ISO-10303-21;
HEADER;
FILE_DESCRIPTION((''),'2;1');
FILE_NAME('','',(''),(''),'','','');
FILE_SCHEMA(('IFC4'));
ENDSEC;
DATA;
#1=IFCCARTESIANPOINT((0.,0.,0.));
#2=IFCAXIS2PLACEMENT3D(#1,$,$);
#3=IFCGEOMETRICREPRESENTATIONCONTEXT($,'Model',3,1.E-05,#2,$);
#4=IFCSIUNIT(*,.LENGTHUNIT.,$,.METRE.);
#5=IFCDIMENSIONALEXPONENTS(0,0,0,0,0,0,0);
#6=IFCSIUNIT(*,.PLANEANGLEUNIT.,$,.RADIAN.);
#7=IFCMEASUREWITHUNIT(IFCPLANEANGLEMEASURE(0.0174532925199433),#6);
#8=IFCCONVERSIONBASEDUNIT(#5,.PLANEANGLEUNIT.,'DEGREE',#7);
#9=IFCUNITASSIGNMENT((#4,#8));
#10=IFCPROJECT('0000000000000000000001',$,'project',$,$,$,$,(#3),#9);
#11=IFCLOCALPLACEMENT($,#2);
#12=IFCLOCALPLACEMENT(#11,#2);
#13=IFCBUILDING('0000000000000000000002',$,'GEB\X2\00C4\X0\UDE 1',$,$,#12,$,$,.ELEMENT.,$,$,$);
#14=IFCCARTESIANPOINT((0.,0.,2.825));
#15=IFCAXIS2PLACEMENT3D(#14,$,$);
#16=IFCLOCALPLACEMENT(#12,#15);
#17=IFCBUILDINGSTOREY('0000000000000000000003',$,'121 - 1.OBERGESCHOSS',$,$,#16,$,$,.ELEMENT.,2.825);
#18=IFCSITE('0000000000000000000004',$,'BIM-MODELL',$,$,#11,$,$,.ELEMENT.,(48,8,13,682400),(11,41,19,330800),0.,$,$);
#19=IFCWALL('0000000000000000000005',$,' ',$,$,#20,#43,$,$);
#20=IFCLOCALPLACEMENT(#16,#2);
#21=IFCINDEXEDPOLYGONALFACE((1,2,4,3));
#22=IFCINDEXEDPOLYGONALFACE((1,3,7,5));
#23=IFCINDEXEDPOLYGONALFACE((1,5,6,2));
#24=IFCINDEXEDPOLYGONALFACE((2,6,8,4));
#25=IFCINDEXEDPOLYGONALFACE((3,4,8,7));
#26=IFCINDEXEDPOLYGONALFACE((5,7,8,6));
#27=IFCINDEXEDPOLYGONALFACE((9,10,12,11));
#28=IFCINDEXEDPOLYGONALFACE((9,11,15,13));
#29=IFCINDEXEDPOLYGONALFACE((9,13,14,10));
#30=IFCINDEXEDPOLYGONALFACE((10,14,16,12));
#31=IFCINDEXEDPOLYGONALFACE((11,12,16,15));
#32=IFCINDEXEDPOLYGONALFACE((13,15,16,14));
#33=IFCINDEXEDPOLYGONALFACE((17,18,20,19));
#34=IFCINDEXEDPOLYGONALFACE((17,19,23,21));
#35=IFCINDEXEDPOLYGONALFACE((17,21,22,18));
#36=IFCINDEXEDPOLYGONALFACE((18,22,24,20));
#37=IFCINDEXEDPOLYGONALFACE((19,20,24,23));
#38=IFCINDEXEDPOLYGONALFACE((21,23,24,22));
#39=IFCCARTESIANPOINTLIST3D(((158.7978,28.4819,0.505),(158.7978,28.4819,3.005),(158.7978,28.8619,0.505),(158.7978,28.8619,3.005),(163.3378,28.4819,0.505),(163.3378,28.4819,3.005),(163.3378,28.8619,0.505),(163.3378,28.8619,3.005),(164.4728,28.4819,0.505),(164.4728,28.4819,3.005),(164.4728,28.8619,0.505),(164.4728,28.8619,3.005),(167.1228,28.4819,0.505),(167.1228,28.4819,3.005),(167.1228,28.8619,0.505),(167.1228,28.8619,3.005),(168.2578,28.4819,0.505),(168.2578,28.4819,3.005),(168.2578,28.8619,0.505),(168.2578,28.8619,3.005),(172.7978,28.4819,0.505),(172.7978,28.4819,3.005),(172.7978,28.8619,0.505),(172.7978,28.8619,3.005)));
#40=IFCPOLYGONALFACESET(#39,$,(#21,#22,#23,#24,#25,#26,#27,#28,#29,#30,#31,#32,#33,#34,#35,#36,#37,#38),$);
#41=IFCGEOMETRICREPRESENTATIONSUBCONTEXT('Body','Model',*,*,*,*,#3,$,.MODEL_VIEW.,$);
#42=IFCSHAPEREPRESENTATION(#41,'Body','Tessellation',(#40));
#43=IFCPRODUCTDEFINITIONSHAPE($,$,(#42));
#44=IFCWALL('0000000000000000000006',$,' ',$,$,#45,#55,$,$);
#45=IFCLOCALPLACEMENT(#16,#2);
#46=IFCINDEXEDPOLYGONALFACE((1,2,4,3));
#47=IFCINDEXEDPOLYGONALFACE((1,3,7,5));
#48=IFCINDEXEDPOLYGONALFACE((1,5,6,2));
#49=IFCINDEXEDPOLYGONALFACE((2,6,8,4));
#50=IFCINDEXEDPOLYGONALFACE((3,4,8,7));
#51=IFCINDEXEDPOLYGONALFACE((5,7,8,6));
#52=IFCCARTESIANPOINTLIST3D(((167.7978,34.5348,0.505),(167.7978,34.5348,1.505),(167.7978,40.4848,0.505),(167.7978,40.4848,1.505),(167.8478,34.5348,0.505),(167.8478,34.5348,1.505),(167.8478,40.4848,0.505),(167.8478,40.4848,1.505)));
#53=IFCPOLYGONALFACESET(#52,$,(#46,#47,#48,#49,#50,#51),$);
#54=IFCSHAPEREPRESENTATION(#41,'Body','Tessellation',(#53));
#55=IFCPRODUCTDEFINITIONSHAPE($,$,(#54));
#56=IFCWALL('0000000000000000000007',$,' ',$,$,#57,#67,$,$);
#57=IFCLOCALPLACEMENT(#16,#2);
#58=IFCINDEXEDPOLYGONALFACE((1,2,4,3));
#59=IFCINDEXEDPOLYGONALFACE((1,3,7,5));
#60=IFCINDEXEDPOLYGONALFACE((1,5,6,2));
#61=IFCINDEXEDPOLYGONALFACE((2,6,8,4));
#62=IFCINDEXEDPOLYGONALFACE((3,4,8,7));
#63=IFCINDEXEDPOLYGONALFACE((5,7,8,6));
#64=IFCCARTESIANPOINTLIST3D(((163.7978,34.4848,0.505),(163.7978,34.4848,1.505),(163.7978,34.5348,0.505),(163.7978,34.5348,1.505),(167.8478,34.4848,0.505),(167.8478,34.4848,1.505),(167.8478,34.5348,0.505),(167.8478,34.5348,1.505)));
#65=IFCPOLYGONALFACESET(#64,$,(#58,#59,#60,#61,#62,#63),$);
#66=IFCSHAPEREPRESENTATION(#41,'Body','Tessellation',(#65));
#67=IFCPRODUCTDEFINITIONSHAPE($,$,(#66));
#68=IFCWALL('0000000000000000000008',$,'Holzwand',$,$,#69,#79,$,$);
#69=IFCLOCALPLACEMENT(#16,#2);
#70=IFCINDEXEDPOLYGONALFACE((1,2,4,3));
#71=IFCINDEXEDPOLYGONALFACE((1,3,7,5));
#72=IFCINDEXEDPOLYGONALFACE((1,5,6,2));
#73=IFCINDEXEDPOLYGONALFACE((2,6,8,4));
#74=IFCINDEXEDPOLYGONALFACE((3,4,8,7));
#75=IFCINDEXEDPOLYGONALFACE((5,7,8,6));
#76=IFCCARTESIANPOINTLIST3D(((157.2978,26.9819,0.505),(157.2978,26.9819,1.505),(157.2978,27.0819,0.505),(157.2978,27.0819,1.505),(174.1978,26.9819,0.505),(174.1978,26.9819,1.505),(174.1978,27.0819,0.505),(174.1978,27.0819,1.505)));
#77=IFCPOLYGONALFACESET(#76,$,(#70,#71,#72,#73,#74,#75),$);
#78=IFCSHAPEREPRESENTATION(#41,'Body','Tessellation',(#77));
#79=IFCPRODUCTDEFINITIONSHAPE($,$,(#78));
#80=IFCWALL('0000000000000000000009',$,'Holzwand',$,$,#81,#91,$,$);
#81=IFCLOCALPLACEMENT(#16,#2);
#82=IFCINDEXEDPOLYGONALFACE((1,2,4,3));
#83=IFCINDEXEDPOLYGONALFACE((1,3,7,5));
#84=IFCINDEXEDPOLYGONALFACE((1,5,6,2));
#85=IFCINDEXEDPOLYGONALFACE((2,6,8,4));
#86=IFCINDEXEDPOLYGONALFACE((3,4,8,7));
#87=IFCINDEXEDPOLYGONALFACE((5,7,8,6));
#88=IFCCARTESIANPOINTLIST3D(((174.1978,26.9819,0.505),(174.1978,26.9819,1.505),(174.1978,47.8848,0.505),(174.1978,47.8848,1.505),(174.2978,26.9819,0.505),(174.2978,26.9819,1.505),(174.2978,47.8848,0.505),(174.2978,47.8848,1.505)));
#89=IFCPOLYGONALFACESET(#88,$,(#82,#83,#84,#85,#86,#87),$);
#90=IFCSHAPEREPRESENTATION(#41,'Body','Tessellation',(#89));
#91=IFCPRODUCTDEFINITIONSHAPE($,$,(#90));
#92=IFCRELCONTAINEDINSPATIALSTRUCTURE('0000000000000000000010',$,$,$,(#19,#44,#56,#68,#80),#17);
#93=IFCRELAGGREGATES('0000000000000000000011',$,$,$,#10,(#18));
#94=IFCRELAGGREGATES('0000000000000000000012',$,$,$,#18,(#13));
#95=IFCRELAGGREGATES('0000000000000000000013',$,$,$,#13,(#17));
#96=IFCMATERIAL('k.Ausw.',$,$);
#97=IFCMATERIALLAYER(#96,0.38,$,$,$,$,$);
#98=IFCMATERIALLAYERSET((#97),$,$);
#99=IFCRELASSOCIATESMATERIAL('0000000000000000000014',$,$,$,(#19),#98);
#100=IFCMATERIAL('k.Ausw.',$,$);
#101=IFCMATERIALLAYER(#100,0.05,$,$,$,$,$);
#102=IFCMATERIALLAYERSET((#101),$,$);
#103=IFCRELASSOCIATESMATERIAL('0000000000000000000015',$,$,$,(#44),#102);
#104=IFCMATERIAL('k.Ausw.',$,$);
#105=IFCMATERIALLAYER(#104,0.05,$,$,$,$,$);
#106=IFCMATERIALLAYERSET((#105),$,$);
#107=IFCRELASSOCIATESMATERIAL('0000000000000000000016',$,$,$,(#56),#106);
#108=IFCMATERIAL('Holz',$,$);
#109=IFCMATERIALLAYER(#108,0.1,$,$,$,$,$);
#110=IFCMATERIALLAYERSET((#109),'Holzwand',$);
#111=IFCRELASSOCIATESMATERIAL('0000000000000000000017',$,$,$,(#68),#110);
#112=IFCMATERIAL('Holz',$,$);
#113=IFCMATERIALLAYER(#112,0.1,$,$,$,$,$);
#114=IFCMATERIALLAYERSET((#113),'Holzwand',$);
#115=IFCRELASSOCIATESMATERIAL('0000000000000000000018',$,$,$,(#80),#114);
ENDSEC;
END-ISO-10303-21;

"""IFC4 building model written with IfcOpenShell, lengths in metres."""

from ifc_helpers import new_model, entity, si_unit, converted_unit, frame, frame_2d, origin, origin_with_axes, place, context, subcontext, project, spatial, polyline, rectangle, outline, extrude, material, layer, layer_set, layer_usage, element, save


model = new_model("IFC4")

# Units and contexts
model_context = context("Model", 3, precision=1e-05, world=origin())
body_context = subcontext(model_context, "Body", "Model", "MODEL_VIEW")
ifc_project = project(units=[si_unit("LENGTHUNIT", "METRE"), converted_unit("PLANEANGLEUNIT", "DEGREE", entity("IfcPlaneAngleMeasure", 0.0174532925199433), si_unit("PLANEANGLEUNIT", "RADIAN"), dimensions=[0, 0, 0, 0, 0, 0, 0])], contexts=[model_context])

# Site, building, storey
site_placement = place(None, origin())
site = spatial("IfcSite", under=ifc_project, at=site_placement, Name="BIM-MODELL", CompositionType="ELEMENT", RefLatitude=(48, 8, 13, 682400), RefLongitude=(11, 41, 19, 330800), RefElevation=0.0)
building_placement = place(site_placement, origin())
building = spatial("IfcBuilding", under=site, at=building_placement, Name="GEBÄUDE 1", CompositionType="ELEMENT")
storey_placement = place(building_placement, frame((0.0, 0.0, 2.825)))
storey = spatial("IfcBuildingStorey", under=building, at=storey_placement, Name="121 - 1.OBERGESCHOSS", CompositionType="ELEMENT", Elevation=2.825)

# Wall, openings
ifc_material_1 = material(Name="k.Ausw.")
ifc_layer_1 = layer(ifc_material_1, 0.38)
ifc_layer_set_1 = layer_set([ifc_layer_1])
ifc_layer_usage_1 = layer_usage(ifc_layer_set_1, "AXIS2", "POSITIVE", 0.0)
wall_1_placement = place(storey_placement, frame((158.7978, 28.4819, 0.505), z_axis=(0.0, 0.0, 1.0), x_axis=(1.0, 0.0, 0.0)))
wall_1 = element("IfcWall", 1, at=wall_1_placement, inside=storey, material=ifc_layer_usage_1, Name=" ", context=body_context, shape_type="SweptSolid", body=[
    extrude(rectangle(XDim=14.0, YDim=0.38, at=frame_2d((7.0, 0.19), x_axis=(1.0, 0.0))), origin_with_axes(), (0.0, 0.0, 1.0), 2.5),
])
opening_1_placement = place(wall_1_placement, frame((9.46, 0.38, 0.0), z_axis=(0.0, -1.0, 0.0), x_axis=(0.0, 0.0, 1.0)))
element("IfcOpeningElement", 2, at=opening_1_placement, cuts=wall_1, ObjectType="Opening", context=body_context, shape_type="SweptSolid", body=[
    extrude(outline(polyline([(0.0, 1.135), (2.5, 1.135), (2.5, 0.0), (0.0, 0.0), (0.0, 1.135)])), origin_with_axes(), (0.0, 0.0, 1.0), 0.38),
])
opening_2_placement = place(wall_1_placement, frame((5.675, 0.38, 0.0), z_axis=(0.0, -1.0, 0.0), x_axis=(0.0, 0.0, 1.0)))
element("IfcOpeningElement", 3, at=opening_2_placement, cuts=wall_1, ObjectType="Opening", context=body_context, shape_type="SweptSolid", body=[
    extrude(outline(polyline([(0.0, 1.135), (2.5, 1.135), (2.5, 0.0), (0.0, 0.0), (0.0, 1.135)])), origin_with_axes(), (0.0, 0.0, 1.0), 0.38),
])

# Walls
ifc_material_2 = material(Name="k.Ausw.")
ifc_layer_2 = layer(ifc_material_2, 0.05)
ifc_layer_set_2 = layer_set([ifc_layer_2])
ifc_layer_usage_2 = layer_usage(ifc_layer_set_2, "AXIS2", "POSITIVE", 0.0)
wall_2_placement = place(storey_placement, frame((167.8478, 34.5348, 0.505), z_axis=(0.0, 0.0, 1.0), x_axis=(0.0, 1.0, 0.0)))
element("IfcWall", 4, at=wall_2_placement, inside=storey, material=ifc_layer_usage_2, Name=" ", context=body_context, shape_type="SweptSolid", body=[
    extrude(rectangle(XDim=5.95, YDim=0.05, at=frame_2d((2.975, 0.025), x_axis=(1.0, 0.0))), origin_with_axes(), (0.0, 0.0, 1.0), 1.0),
])
ifc_material_3 = material(Name="k.Ausw.")
ifc_layer_3 = layer(ifc_material_3, 0.05)
ifc_layer_set_3 = layer_set([ifc_layer_3])
ifc_layer_usage_3 = layer_usage(ifc_layer_set_3, "AXIS2", "POSITIVE", 0.0)
wall_3_placement = place(storey_placement, frame((163.7978, 34.4848, 0.505), z_axis=(0.0, 0.0, 1.0), x_axis=(1.0, 0.0, 0.0)))
element("IfcWall", 5, at=wall_3_placement, inside=storey, material=ifc_layer_usage_3, Name=" ", context=body_context, shape_type="SweptSolid", body=[
    extrude(rectangle(XDim=4.05, YDim=0.05, at=frame_2d((2.025, 0.025), x_axis=(1.0, 0.0))), origin_with_axes(), (0.0, 0.0, 1.0), 1.0),
])
ifc_material_4 = material(Name="Holz")
ifc_layer_4 = layer(ifc_material_4, 0.1)
ifc_layer_set_4 = layer_set([ifc_layer_4], Name="Holzwand")
ifc_layer_usage_4 = layer_usage(ifc_layer_set_4, "AXIS2", "POSITIVE", 0.0)
wall_4_placement = place(storey_placement, frame((157.2978, 26.9819, 0.505)))
element("IfcWall", 6, at=wall_4_placement, inside=storey, material=ifc_layer_usage_4, Name="Holzwand", context=body_context, shape_type="SweptSolid", body=[
    extrude(rectangle(XDim=16.9, YDim=0.1, at=frame_2d((8.45, 0.05), x_axis=(1.0, 0.0))), origin_with_axes(), (0.0, 0.0, 1.0), 1.0),
])
ifc_material_5 = material(Name="Holz")
ifc_layer_5 = layer(ifc_material_5, 0.1)
ifc_layer_set_5 = layer_set([ifc_layer_5], Name="Holzwand")
ifc_layer_usage_5 = layer_usage(ifc_layer_set_5, "AXIS2", "POSITIVE", 0.0)
wall_5_placement = place(storey_placement, frame((174.2978, 26.9819, 0.505), z_axis=(0.0, 0.0, 1.0), x_axis=(0.0, 1.0, 0.0)))
element("IfcWall", 7, at=wall_5_placement, inside=storey, material=ifc_layer_usage_5, Name="Holzwand", context=body_context, shape_type="SweptSolid", body=[
    extrude(rectangle(XDim=20.9029, YDim=0.1, at=frame_2d((10.4514, 0.05), x_axis=(1.0, 0.0))), origin_with_axes(), (0.0, 0.0, 1.0), 1.0),
])

save(model, "model.ifc")
